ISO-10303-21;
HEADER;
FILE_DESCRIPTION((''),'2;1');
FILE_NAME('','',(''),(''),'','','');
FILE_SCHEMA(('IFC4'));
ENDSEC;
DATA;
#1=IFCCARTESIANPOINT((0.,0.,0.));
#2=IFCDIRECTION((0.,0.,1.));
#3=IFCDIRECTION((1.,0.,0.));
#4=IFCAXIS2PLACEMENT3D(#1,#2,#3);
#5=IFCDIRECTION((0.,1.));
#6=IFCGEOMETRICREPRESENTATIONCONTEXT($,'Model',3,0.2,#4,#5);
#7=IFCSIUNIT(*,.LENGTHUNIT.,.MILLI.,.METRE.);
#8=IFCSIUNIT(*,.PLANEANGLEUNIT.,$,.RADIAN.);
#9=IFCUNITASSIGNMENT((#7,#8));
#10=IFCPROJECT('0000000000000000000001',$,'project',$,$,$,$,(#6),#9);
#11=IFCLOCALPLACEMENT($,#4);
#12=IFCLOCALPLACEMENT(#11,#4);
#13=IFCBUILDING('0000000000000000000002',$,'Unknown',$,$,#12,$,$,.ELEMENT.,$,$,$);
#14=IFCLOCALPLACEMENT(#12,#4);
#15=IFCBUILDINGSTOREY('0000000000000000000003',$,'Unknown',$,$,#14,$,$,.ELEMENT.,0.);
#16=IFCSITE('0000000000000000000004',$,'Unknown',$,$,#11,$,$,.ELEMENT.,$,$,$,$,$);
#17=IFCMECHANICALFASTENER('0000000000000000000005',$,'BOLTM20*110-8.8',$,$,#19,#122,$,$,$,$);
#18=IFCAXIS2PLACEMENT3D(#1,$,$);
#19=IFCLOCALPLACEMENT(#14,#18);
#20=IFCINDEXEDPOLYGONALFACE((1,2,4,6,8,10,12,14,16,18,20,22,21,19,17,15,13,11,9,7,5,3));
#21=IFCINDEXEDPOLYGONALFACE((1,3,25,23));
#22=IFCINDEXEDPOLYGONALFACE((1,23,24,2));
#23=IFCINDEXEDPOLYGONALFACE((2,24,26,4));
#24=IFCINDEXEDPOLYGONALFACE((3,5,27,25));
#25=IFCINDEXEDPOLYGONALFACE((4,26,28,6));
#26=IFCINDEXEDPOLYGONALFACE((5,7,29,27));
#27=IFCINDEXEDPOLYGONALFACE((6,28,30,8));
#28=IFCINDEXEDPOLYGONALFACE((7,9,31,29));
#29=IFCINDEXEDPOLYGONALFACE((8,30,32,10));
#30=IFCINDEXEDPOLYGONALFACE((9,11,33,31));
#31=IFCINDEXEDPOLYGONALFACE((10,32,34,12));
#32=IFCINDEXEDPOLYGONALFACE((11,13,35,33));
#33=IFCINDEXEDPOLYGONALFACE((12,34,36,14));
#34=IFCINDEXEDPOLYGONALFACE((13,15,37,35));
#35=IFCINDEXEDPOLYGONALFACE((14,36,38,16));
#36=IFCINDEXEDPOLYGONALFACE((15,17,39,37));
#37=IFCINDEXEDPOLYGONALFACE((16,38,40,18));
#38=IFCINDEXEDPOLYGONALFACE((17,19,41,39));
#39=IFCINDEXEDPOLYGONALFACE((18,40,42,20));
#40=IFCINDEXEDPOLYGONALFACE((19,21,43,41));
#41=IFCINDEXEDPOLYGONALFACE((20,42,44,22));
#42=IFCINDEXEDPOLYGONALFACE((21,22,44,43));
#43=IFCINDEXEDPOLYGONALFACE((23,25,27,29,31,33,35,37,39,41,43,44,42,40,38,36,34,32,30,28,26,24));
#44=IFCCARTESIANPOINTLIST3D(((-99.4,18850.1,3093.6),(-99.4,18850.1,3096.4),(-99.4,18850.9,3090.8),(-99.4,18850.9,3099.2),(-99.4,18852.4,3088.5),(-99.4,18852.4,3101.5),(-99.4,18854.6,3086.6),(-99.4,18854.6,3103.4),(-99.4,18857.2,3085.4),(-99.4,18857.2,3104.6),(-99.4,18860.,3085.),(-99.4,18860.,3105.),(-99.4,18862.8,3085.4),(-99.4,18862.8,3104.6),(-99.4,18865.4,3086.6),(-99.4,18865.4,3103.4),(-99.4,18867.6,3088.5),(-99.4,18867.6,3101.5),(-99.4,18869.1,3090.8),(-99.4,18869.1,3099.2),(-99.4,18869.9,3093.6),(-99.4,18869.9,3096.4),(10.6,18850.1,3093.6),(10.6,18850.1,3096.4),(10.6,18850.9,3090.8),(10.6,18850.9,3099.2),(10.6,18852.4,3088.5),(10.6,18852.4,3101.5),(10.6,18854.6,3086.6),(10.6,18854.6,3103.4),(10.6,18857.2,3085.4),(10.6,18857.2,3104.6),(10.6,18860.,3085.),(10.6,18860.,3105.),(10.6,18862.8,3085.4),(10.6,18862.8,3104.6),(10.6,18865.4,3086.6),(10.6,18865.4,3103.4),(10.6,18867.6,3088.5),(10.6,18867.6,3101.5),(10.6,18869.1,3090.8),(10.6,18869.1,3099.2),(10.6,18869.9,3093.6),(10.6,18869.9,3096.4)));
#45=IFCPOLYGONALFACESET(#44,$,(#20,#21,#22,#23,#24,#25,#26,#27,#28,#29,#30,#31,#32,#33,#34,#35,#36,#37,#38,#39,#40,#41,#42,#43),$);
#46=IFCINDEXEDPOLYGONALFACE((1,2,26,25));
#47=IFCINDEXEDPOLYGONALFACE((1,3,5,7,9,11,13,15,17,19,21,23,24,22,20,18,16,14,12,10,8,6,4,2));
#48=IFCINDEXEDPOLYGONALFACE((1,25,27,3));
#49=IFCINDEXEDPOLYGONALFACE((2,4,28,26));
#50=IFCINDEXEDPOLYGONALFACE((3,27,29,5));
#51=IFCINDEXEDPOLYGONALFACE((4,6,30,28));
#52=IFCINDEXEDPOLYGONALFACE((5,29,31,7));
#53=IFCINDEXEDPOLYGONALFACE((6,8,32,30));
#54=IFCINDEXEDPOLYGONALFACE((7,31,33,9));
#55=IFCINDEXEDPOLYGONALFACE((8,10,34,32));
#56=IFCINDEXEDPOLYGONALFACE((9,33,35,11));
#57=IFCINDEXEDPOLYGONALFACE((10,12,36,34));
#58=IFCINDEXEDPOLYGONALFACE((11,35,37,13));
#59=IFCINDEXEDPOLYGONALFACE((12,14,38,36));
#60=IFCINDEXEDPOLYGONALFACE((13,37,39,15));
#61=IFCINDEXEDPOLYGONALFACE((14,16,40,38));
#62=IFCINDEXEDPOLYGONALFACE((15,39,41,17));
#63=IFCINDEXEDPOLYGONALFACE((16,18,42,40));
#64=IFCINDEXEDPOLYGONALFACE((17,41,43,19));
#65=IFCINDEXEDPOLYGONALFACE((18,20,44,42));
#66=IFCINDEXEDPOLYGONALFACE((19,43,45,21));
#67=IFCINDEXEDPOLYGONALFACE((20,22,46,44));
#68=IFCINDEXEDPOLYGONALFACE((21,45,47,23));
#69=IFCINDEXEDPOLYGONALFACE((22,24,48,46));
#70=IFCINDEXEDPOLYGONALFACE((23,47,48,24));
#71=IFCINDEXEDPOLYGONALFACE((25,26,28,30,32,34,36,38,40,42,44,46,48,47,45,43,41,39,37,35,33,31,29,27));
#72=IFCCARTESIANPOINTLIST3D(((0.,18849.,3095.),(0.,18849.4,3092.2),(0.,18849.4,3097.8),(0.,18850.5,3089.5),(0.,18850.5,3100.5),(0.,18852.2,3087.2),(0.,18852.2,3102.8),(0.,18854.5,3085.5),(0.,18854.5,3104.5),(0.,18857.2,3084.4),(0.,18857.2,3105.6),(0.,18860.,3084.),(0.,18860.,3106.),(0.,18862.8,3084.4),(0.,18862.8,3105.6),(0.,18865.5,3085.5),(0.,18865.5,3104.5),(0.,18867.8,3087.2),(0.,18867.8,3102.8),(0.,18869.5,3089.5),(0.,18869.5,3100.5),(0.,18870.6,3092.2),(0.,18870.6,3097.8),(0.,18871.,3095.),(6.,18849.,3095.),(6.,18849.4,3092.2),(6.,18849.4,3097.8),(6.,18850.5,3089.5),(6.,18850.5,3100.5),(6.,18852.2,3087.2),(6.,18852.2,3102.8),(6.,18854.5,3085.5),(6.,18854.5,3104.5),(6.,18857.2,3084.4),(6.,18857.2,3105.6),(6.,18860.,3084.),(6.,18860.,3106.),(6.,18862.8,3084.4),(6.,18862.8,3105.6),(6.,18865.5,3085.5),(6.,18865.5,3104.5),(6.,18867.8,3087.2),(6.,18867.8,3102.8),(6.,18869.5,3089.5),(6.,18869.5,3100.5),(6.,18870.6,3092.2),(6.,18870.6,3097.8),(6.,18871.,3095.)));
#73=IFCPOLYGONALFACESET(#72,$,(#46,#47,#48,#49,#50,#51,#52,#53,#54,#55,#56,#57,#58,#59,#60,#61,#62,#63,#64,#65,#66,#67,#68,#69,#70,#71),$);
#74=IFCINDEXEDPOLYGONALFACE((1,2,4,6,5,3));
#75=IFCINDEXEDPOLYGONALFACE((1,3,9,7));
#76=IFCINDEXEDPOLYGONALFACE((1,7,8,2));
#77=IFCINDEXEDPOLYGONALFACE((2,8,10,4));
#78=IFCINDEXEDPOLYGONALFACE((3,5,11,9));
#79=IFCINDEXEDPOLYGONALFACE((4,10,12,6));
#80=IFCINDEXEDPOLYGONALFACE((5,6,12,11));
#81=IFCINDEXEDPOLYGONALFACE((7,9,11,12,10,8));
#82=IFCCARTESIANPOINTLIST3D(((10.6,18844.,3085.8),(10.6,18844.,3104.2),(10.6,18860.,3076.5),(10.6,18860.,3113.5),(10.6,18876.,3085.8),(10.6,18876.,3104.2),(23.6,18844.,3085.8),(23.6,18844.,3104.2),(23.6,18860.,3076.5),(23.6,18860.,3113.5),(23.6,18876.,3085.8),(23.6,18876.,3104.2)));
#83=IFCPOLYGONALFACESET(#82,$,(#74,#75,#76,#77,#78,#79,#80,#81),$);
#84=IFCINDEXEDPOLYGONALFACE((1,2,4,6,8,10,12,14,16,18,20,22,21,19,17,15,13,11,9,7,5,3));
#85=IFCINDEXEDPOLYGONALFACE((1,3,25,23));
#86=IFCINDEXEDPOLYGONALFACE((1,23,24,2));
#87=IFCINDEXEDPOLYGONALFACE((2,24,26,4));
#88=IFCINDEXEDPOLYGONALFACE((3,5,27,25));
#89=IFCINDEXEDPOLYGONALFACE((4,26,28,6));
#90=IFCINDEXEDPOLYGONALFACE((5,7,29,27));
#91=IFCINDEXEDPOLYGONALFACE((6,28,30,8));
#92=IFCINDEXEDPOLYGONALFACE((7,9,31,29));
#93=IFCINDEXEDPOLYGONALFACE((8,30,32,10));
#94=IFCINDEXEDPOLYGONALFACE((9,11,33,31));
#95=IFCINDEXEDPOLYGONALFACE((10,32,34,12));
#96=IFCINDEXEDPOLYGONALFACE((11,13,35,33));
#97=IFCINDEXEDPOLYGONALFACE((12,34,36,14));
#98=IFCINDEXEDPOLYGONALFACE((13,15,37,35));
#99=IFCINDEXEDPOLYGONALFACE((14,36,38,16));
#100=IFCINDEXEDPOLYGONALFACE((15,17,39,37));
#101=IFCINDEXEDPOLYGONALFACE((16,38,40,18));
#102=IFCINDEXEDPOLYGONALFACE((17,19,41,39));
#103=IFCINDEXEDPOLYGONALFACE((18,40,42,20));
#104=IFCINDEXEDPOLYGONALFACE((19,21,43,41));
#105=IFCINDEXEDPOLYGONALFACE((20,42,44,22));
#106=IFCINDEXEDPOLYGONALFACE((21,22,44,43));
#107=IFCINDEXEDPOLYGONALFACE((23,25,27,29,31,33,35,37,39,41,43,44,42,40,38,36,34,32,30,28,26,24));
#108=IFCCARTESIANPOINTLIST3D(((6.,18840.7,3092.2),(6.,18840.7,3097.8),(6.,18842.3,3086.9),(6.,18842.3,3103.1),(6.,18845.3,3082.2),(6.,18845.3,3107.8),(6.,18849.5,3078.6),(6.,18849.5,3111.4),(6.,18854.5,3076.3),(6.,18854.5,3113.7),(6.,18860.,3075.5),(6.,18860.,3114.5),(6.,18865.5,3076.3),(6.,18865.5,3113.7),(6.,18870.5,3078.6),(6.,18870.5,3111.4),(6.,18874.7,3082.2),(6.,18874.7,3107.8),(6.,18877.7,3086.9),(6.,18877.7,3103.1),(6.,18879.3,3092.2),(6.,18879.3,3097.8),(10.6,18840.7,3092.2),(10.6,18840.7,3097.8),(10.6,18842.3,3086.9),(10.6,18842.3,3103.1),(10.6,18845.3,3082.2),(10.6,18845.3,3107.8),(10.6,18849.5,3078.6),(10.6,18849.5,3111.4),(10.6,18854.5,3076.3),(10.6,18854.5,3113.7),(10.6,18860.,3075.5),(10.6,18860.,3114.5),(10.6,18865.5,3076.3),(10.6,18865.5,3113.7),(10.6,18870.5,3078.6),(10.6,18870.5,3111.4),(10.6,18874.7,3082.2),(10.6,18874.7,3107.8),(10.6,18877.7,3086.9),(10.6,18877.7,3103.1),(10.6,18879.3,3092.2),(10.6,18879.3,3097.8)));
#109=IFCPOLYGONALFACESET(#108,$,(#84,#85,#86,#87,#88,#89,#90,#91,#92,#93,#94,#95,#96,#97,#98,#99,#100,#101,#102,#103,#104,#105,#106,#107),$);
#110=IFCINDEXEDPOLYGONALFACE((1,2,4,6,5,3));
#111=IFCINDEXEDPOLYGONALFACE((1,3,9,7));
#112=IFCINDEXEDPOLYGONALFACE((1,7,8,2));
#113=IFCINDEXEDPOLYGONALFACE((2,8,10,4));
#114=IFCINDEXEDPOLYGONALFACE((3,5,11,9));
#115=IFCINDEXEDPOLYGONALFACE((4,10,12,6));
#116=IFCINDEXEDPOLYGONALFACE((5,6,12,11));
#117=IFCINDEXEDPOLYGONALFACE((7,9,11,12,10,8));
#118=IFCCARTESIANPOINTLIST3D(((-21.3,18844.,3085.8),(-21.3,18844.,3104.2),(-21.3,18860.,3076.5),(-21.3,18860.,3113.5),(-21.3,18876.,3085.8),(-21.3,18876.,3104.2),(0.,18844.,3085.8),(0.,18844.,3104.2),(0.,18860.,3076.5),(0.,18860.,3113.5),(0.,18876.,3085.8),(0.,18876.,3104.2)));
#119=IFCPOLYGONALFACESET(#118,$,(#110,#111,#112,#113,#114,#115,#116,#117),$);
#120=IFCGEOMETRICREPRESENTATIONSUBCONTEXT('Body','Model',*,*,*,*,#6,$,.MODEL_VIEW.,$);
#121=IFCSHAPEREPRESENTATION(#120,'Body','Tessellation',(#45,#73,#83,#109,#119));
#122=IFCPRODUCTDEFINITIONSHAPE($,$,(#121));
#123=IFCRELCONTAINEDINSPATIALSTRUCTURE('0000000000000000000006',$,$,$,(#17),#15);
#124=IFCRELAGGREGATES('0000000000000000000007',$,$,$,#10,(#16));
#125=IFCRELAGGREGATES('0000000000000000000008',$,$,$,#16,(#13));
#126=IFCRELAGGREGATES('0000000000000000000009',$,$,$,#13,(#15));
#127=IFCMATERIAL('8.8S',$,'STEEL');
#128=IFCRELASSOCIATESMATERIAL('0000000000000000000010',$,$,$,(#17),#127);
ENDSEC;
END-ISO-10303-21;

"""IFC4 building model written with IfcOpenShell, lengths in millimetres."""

from ifc_helpers import new_model, si_unit, direction, frame, origin_with_axes, place, context, subcontext, project, spatial, line, arc, indexed_curve, outline, extrude, source, transform, mapped, material, element, save


model = new_model("IFC4")

# Units and contexts
model_context = context("Model", 3, precision=0.2, world=origin_with_axes(), true_north=direction((0.0, 1.0)))
body_context = subcontext(model_context, "Body", "Model", "MODEL_VIEW")
ifc_project = project(units=[si_unit("LENGTHUNIT", "METRE", prefix="MILLI"), si_unit("PLANEANGLEUNIT", "RADIAN")], contexts=[model_context])

# Site, building, storey
site_placement = place(None, origin_with_axes())
site = spatial("IfcSite", under=ifc_project, at=site_placement, Name="Unknown", CompositionType="ELEMENT")
building_placement = place(site_placement, origin_with_axes())
building = spatial("IfcBuilding", under=site, at=building_placement, Name="Unknown", CompositionType="ELEMENT")
storey_placement = place(building_placement, origin_with_axes())
storey = spatial("IfcBuildingStorey", under=building, at=storey_placement, Name="Unknown", CompositionType="ELEMENT", Elevation=0.0)

# Mechanical fastener
ifc_material_1 = material(Name="8.8S", Category="STEEL")
shared_shape_1 = source(origin_with_axes(), body_context, "Body", "SweptSolid", [
    extrude(outline(indexed_curve([(10.0, 0.0), (0.0, 10.0), (-10.0, 0.0), (0.0, -10.0)], segments=[arc(1, 2, 3), arc(3, 4, 1)])), frame((0.0, 0.0, 4.6), z_axis=(0.0, 0.0, -1.0), x_axis=(0.0, 1.0, 0.0)), (0.0, 0.0, 1.0), 110.0),
    extrude(outline(indexed_curve([(0.0, 11.0), (7.8, 7.8), (11.0, 0.0), (7.8, -7.8), (0.0, -11.0), (-1.0, -11.0), (-11.0, 0.0), (-7.8, 7.8)], segments=[arc(1, 2, 3), arc(3, 4, 5), arc(5, 6, 7), arc(7, 8, 1)])), frame((0.0, 0.0, 0.0), z_axis=(0.0, 0.0, -1.0), x_axis=(0.0, 1.0, 0.0)), (0.0, 0.0, 1.0), 6.0),
    extrude(outline(indexed_curve([(18.5, 0.0), (9.2, 16.0), (-9.2, 16.0), (-18.5, 0.0), (-9.2, -16.0), (9.2, -16.0)], segments=[line(1, 2, 3, 4, 5, 6, 1)])), frame((0.0, 0.0, 17.6), z_axis=(0.0, 0.0, -1.0), x_axis=(0.0, 1.0, 0.0)), (0.0, 0.0, 1.0), 13.0),
    extrude(outline(indexed_curve([(19.5, 0.0), (0.0, 19.5), (-19.5, 0.0), (0.0, -19.5)], segments=[arc(1, 2, 3), arc(3, 4, 1)])), frame((0.0, 0.0, 4.6), z_axis=(0.0, 0.0, -1.0), x_axis=(0.0, 1.0, 0.0)), (0.0, 0.0, 1.0), 4.6),
    extrude(outline(indexed_curve([(18.5, 0.0), (9.2, 16.0), (-9.2, 16.0), (-18.5, 0.0), (-9.2, -16.0), (9.2, -16.0)], segments=[line(1, 2, 3, 4, 5, 6, 1)])), frame((0.0, 0.0, -6.0), z_axis=(0.0, 0.0, -1.0), x_axis=(0.0, 1.0, 0.0)), (0.0, 0.0, 1.0), 21.3),
])
mechanical_fastener_1_placement = place(storey_placement, frame((6.0, 18860.0, 3095.0), z_axis=(1.0, 0.0, 0.0), x_axis=(0.0, 1.0, 0.0)))
element("IfcMechanicalFastener", 1, at=mechanical_fastener_1_placement, inside=storey, material=ifc_material_1, Name="BOLTM20*110-8.8", context=body_context, shape_type="MappedRepresentation", body=[
    mapped(shared_shape_1, transform((0.0, 0.0, 0.0))),
])

save(model, "model.ifc")
